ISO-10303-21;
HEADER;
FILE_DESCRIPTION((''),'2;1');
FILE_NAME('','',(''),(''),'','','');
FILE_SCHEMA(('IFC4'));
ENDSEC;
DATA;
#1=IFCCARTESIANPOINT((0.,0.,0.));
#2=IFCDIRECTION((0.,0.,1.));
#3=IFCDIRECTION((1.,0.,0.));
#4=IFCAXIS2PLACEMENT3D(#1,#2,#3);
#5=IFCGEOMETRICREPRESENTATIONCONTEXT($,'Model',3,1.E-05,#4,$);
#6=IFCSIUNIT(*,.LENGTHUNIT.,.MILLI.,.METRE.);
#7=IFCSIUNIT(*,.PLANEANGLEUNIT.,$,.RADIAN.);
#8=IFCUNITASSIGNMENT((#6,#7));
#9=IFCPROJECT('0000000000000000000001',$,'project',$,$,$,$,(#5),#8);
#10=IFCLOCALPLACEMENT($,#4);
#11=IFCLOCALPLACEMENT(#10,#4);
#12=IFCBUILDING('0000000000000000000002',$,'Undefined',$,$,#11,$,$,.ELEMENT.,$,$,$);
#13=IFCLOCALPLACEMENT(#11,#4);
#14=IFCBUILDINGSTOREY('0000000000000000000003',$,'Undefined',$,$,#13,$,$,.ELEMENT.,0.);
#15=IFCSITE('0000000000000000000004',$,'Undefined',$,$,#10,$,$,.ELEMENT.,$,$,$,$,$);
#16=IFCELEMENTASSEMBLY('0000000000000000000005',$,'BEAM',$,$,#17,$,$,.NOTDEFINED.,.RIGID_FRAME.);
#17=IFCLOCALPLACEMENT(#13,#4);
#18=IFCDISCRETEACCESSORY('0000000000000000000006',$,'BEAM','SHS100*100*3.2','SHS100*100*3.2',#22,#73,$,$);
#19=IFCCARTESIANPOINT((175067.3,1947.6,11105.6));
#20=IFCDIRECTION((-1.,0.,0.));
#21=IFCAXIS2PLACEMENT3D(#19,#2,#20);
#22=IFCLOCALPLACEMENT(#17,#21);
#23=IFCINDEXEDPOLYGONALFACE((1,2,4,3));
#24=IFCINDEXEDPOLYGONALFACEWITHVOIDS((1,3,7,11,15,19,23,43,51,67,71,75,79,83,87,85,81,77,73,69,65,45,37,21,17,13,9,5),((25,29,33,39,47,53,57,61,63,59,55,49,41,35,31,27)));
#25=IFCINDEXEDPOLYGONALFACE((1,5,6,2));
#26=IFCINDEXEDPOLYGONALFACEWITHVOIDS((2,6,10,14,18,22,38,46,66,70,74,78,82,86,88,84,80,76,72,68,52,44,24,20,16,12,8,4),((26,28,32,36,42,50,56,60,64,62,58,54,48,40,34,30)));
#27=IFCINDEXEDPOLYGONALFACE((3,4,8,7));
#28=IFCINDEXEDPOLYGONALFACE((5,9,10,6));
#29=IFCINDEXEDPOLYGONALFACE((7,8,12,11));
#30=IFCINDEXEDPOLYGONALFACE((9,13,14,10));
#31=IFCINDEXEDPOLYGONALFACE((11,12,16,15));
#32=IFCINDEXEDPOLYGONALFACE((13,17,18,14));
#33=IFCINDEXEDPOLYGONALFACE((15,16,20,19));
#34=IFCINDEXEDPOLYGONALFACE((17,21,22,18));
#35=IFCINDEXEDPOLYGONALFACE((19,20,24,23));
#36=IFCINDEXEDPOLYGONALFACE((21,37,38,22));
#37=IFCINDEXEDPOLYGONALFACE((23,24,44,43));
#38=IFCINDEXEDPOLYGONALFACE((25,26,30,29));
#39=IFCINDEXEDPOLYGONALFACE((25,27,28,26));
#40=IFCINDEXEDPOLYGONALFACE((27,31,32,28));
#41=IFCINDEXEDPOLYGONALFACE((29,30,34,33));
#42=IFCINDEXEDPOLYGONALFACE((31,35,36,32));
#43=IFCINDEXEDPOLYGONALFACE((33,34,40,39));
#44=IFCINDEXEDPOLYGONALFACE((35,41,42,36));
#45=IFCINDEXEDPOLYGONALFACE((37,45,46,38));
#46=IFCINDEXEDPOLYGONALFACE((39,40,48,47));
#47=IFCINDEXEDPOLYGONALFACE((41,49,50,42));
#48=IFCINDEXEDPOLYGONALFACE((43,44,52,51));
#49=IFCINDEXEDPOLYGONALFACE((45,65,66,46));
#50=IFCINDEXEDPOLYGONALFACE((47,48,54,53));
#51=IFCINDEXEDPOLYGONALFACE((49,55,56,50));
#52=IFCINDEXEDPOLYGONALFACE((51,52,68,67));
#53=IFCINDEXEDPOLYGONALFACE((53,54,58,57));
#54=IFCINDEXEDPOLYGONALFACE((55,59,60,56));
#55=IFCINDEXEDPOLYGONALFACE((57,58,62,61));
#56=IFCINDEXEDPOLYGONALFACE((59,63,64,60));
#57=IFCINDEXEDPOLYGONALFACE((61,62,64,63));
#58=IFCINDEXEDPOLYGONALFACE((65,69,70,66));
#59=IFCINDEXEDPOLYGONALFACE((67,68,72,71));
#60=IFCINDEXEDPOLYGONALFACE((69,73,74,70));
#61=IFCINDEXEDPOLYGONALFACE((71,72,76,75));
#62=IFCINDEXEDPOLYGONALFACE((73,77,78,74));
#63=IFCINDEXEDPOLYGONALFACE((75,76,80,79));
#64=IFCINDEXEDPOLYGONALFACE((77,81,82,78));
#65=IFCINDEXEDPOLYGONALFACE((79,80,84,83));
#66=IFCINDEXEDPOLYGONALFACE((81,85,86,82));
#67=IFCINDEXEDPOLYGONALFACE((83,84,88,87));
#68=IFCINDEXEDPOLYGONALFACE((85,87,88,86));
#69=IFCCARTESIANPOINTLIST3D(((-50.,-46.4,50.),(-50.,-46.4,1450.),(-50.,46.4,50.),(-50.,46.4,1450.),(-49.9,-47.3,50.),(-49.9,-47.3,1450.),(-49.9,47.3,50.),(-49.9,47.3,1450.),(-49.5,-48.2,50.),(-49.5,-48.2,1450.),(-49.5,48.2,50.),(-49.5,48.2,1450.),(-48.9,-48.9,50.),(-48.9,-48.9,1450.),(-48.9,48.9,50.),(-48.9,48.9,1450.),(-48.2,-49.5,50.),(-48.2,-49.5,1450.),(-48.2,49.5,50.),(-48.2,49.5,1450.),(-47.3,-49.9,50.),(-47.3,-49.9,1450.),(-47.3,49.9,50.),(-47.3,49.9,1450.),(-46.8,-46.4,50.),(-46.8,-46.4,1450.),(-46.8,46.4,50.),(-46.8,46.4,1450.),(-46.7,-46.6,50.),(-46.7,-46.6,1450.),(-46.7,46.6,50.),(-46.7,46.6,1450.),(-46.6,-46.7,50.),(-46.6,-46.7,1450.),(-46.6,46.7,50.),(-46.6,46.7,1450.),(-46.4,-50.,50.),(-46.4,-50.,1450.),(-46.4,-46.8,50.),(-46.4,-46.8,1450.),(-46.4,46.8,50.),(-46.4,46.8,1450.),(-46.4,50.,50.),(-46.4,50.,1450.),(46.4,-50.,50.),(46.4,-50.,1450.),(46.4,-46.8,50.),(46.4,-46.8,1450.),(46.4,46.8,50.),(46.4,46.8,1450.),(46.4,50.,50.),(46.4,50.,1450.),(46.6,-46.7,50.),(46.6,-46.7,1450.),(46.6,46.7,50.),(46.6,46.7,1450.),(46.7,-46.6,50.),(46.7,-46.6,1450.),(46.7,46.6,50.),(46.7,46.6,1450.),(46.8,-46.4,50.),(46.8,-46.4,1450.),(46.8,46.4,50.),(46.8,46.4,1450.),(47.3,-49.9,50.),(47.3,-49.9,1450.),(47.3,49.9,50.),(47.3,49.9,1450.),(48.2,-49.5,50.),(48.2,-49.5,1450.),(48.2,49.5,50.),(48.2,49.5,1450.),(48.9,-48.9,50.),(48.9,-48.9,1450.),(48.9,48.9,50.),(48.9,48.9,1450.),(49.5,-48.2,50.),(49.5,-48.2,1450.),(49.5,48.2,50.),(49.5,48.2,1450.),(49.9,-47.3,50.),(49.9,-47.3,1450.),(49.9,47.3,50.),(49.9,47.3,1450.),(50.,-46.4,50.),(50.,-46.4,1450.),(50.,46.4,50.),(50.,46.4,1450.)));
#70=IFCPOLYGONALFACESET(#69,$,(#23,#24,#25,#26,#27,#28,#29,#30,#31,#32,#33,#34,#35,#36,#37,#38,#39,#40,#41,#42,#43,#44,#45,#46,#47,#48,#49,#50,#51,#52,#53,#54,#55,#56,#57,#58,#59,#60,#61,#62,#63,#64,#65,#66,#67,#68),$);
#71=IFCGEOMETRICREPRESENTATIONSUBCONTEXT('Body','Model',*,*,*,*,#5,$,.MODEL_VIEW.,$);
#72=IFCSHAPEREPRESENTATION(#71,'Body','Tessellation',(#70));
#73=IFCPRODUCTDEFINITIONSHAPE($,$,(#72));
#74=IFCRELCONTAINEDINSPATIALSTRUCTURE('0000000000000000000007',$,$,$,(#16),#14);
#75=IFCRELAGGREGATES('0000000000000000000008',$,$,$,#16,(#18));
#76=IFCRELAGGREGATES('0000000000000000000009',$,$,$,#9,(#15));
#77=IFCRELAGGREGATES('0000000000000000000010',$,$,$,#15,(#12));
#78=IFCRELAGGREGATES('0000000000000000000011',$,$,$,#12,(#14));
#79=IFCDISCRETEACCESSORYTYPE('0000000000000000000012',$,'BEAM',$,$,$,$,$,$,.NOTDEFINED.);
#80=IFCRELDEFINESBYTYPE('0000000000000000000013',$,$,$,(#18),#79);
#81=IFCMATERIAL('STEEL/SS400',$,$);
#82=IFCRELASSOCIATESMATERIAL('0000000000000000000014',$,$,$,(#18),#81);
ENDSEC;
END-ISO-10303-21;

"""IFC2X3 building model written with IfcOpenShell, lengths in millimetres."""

from ifc_helpers import new_model, si_unit, frame, origin_with_axes, origin_2d_with_axis, place, context, subcontext, project, spatial, hollow_rectangle, extrude, clip, halfspace, material, type_object, element, aggregate, save


model = new_model("IFC2X3")

# Units and contexts
model_context = context("Model", 3, precision=1e-05, world=origin_with_axes())
body_context = subcontext(model_context, "Body", "Model", "MODEL_VIEW")
ifc_project = project(units=[si_unit("LENGTHUNIT", "METRE", prefix="MILLI"), si_unit("PLANEANGLEUNIT", "RADIAN")], contexts=[model_context])

# Site, building, storey
site_placement = place(None, origin_with_axes())
site = spatial("IfcSite", under=ifc_project, at=site_placement, Name="Undefined", CompositionType="ELEMENT")
building_placement = place(site_placement, origin_with_axes())
building = spatial("IfcBuilding", under=site, at=building_placement, Name="Undefined", CompositionType="ELEMENT")
storey_placement = place(building_placement, origin_with_axes())
storey = spatial("IfcBuildingStorey", under=building, at=storey_placement, Name="Undefined", CompositionType="ELEMENT", Elevation=0.0)

# Shared definitions
ifc_material_1 = material(Name="STEEL/SS400")

# Element assembly, discrete accessory
assembly_1_placement = place(storey_placement, origin_with_axes())
assembly_1 = element("IfcElementAssembly", 1, at=assembly_1_placement, inside=storey, Name="BEAM", AssemblyPlace="NOTDEFINED", PredefinedType="RIGID_FRAME")
discrete_accessory_type_1 = type_object("IfcDiscreteAccessoryType", Name="BEAM")
discrete_accessory_1_placement = place(assembly_1_placement, frame((175067.3, 1947.6, 11105.6), z_axis=(0.0, 0.0, 1.0), x_axis=(-1.0, 0.0, 0.0)))
discrete_accessory_1 = element("IfcDiscreteAccessory", 2, at=discrete_accessory_1_placement, type_object=discrete_accessory_type_1, material=ifc_material_1, Name="BEAM", Description="SHS100*100*3.2", ObjectType="SHS100*100*3.2", context=body_context, shape_type="Clipping", body=[
    clip(clip(extrude(hollow_rectangle(XDim=100.0, YDim=100.0, WallThickness=3.2, InnerFilletRadius=0.4, OuterFilletRadius=3.6, at=origin_2d_with_axis()), frame((0.0, 0.0, 1450.0), z_axis=(0.0, 0.0, -1.0), x_axis=(0.0, 1.0, 0.0)), (0.0, 0.0, 1.0), 1400.0), halfspace(frame((1000.0, 0.0, 1450.0), z_axis=(0.0, 0.0, -1.0), x_axis=(0.0, 1.0, 0.0)), True)), halfspace(frame((1000.0, 0.0, 50.0), z_axis=(0.0, 0.0, 1.0), x_axis=(0.0, -1.0, 0.0)), True)),
])
aggregate(assembly_1, [discrete_accessory_1])

save(model, "model.ifc")
